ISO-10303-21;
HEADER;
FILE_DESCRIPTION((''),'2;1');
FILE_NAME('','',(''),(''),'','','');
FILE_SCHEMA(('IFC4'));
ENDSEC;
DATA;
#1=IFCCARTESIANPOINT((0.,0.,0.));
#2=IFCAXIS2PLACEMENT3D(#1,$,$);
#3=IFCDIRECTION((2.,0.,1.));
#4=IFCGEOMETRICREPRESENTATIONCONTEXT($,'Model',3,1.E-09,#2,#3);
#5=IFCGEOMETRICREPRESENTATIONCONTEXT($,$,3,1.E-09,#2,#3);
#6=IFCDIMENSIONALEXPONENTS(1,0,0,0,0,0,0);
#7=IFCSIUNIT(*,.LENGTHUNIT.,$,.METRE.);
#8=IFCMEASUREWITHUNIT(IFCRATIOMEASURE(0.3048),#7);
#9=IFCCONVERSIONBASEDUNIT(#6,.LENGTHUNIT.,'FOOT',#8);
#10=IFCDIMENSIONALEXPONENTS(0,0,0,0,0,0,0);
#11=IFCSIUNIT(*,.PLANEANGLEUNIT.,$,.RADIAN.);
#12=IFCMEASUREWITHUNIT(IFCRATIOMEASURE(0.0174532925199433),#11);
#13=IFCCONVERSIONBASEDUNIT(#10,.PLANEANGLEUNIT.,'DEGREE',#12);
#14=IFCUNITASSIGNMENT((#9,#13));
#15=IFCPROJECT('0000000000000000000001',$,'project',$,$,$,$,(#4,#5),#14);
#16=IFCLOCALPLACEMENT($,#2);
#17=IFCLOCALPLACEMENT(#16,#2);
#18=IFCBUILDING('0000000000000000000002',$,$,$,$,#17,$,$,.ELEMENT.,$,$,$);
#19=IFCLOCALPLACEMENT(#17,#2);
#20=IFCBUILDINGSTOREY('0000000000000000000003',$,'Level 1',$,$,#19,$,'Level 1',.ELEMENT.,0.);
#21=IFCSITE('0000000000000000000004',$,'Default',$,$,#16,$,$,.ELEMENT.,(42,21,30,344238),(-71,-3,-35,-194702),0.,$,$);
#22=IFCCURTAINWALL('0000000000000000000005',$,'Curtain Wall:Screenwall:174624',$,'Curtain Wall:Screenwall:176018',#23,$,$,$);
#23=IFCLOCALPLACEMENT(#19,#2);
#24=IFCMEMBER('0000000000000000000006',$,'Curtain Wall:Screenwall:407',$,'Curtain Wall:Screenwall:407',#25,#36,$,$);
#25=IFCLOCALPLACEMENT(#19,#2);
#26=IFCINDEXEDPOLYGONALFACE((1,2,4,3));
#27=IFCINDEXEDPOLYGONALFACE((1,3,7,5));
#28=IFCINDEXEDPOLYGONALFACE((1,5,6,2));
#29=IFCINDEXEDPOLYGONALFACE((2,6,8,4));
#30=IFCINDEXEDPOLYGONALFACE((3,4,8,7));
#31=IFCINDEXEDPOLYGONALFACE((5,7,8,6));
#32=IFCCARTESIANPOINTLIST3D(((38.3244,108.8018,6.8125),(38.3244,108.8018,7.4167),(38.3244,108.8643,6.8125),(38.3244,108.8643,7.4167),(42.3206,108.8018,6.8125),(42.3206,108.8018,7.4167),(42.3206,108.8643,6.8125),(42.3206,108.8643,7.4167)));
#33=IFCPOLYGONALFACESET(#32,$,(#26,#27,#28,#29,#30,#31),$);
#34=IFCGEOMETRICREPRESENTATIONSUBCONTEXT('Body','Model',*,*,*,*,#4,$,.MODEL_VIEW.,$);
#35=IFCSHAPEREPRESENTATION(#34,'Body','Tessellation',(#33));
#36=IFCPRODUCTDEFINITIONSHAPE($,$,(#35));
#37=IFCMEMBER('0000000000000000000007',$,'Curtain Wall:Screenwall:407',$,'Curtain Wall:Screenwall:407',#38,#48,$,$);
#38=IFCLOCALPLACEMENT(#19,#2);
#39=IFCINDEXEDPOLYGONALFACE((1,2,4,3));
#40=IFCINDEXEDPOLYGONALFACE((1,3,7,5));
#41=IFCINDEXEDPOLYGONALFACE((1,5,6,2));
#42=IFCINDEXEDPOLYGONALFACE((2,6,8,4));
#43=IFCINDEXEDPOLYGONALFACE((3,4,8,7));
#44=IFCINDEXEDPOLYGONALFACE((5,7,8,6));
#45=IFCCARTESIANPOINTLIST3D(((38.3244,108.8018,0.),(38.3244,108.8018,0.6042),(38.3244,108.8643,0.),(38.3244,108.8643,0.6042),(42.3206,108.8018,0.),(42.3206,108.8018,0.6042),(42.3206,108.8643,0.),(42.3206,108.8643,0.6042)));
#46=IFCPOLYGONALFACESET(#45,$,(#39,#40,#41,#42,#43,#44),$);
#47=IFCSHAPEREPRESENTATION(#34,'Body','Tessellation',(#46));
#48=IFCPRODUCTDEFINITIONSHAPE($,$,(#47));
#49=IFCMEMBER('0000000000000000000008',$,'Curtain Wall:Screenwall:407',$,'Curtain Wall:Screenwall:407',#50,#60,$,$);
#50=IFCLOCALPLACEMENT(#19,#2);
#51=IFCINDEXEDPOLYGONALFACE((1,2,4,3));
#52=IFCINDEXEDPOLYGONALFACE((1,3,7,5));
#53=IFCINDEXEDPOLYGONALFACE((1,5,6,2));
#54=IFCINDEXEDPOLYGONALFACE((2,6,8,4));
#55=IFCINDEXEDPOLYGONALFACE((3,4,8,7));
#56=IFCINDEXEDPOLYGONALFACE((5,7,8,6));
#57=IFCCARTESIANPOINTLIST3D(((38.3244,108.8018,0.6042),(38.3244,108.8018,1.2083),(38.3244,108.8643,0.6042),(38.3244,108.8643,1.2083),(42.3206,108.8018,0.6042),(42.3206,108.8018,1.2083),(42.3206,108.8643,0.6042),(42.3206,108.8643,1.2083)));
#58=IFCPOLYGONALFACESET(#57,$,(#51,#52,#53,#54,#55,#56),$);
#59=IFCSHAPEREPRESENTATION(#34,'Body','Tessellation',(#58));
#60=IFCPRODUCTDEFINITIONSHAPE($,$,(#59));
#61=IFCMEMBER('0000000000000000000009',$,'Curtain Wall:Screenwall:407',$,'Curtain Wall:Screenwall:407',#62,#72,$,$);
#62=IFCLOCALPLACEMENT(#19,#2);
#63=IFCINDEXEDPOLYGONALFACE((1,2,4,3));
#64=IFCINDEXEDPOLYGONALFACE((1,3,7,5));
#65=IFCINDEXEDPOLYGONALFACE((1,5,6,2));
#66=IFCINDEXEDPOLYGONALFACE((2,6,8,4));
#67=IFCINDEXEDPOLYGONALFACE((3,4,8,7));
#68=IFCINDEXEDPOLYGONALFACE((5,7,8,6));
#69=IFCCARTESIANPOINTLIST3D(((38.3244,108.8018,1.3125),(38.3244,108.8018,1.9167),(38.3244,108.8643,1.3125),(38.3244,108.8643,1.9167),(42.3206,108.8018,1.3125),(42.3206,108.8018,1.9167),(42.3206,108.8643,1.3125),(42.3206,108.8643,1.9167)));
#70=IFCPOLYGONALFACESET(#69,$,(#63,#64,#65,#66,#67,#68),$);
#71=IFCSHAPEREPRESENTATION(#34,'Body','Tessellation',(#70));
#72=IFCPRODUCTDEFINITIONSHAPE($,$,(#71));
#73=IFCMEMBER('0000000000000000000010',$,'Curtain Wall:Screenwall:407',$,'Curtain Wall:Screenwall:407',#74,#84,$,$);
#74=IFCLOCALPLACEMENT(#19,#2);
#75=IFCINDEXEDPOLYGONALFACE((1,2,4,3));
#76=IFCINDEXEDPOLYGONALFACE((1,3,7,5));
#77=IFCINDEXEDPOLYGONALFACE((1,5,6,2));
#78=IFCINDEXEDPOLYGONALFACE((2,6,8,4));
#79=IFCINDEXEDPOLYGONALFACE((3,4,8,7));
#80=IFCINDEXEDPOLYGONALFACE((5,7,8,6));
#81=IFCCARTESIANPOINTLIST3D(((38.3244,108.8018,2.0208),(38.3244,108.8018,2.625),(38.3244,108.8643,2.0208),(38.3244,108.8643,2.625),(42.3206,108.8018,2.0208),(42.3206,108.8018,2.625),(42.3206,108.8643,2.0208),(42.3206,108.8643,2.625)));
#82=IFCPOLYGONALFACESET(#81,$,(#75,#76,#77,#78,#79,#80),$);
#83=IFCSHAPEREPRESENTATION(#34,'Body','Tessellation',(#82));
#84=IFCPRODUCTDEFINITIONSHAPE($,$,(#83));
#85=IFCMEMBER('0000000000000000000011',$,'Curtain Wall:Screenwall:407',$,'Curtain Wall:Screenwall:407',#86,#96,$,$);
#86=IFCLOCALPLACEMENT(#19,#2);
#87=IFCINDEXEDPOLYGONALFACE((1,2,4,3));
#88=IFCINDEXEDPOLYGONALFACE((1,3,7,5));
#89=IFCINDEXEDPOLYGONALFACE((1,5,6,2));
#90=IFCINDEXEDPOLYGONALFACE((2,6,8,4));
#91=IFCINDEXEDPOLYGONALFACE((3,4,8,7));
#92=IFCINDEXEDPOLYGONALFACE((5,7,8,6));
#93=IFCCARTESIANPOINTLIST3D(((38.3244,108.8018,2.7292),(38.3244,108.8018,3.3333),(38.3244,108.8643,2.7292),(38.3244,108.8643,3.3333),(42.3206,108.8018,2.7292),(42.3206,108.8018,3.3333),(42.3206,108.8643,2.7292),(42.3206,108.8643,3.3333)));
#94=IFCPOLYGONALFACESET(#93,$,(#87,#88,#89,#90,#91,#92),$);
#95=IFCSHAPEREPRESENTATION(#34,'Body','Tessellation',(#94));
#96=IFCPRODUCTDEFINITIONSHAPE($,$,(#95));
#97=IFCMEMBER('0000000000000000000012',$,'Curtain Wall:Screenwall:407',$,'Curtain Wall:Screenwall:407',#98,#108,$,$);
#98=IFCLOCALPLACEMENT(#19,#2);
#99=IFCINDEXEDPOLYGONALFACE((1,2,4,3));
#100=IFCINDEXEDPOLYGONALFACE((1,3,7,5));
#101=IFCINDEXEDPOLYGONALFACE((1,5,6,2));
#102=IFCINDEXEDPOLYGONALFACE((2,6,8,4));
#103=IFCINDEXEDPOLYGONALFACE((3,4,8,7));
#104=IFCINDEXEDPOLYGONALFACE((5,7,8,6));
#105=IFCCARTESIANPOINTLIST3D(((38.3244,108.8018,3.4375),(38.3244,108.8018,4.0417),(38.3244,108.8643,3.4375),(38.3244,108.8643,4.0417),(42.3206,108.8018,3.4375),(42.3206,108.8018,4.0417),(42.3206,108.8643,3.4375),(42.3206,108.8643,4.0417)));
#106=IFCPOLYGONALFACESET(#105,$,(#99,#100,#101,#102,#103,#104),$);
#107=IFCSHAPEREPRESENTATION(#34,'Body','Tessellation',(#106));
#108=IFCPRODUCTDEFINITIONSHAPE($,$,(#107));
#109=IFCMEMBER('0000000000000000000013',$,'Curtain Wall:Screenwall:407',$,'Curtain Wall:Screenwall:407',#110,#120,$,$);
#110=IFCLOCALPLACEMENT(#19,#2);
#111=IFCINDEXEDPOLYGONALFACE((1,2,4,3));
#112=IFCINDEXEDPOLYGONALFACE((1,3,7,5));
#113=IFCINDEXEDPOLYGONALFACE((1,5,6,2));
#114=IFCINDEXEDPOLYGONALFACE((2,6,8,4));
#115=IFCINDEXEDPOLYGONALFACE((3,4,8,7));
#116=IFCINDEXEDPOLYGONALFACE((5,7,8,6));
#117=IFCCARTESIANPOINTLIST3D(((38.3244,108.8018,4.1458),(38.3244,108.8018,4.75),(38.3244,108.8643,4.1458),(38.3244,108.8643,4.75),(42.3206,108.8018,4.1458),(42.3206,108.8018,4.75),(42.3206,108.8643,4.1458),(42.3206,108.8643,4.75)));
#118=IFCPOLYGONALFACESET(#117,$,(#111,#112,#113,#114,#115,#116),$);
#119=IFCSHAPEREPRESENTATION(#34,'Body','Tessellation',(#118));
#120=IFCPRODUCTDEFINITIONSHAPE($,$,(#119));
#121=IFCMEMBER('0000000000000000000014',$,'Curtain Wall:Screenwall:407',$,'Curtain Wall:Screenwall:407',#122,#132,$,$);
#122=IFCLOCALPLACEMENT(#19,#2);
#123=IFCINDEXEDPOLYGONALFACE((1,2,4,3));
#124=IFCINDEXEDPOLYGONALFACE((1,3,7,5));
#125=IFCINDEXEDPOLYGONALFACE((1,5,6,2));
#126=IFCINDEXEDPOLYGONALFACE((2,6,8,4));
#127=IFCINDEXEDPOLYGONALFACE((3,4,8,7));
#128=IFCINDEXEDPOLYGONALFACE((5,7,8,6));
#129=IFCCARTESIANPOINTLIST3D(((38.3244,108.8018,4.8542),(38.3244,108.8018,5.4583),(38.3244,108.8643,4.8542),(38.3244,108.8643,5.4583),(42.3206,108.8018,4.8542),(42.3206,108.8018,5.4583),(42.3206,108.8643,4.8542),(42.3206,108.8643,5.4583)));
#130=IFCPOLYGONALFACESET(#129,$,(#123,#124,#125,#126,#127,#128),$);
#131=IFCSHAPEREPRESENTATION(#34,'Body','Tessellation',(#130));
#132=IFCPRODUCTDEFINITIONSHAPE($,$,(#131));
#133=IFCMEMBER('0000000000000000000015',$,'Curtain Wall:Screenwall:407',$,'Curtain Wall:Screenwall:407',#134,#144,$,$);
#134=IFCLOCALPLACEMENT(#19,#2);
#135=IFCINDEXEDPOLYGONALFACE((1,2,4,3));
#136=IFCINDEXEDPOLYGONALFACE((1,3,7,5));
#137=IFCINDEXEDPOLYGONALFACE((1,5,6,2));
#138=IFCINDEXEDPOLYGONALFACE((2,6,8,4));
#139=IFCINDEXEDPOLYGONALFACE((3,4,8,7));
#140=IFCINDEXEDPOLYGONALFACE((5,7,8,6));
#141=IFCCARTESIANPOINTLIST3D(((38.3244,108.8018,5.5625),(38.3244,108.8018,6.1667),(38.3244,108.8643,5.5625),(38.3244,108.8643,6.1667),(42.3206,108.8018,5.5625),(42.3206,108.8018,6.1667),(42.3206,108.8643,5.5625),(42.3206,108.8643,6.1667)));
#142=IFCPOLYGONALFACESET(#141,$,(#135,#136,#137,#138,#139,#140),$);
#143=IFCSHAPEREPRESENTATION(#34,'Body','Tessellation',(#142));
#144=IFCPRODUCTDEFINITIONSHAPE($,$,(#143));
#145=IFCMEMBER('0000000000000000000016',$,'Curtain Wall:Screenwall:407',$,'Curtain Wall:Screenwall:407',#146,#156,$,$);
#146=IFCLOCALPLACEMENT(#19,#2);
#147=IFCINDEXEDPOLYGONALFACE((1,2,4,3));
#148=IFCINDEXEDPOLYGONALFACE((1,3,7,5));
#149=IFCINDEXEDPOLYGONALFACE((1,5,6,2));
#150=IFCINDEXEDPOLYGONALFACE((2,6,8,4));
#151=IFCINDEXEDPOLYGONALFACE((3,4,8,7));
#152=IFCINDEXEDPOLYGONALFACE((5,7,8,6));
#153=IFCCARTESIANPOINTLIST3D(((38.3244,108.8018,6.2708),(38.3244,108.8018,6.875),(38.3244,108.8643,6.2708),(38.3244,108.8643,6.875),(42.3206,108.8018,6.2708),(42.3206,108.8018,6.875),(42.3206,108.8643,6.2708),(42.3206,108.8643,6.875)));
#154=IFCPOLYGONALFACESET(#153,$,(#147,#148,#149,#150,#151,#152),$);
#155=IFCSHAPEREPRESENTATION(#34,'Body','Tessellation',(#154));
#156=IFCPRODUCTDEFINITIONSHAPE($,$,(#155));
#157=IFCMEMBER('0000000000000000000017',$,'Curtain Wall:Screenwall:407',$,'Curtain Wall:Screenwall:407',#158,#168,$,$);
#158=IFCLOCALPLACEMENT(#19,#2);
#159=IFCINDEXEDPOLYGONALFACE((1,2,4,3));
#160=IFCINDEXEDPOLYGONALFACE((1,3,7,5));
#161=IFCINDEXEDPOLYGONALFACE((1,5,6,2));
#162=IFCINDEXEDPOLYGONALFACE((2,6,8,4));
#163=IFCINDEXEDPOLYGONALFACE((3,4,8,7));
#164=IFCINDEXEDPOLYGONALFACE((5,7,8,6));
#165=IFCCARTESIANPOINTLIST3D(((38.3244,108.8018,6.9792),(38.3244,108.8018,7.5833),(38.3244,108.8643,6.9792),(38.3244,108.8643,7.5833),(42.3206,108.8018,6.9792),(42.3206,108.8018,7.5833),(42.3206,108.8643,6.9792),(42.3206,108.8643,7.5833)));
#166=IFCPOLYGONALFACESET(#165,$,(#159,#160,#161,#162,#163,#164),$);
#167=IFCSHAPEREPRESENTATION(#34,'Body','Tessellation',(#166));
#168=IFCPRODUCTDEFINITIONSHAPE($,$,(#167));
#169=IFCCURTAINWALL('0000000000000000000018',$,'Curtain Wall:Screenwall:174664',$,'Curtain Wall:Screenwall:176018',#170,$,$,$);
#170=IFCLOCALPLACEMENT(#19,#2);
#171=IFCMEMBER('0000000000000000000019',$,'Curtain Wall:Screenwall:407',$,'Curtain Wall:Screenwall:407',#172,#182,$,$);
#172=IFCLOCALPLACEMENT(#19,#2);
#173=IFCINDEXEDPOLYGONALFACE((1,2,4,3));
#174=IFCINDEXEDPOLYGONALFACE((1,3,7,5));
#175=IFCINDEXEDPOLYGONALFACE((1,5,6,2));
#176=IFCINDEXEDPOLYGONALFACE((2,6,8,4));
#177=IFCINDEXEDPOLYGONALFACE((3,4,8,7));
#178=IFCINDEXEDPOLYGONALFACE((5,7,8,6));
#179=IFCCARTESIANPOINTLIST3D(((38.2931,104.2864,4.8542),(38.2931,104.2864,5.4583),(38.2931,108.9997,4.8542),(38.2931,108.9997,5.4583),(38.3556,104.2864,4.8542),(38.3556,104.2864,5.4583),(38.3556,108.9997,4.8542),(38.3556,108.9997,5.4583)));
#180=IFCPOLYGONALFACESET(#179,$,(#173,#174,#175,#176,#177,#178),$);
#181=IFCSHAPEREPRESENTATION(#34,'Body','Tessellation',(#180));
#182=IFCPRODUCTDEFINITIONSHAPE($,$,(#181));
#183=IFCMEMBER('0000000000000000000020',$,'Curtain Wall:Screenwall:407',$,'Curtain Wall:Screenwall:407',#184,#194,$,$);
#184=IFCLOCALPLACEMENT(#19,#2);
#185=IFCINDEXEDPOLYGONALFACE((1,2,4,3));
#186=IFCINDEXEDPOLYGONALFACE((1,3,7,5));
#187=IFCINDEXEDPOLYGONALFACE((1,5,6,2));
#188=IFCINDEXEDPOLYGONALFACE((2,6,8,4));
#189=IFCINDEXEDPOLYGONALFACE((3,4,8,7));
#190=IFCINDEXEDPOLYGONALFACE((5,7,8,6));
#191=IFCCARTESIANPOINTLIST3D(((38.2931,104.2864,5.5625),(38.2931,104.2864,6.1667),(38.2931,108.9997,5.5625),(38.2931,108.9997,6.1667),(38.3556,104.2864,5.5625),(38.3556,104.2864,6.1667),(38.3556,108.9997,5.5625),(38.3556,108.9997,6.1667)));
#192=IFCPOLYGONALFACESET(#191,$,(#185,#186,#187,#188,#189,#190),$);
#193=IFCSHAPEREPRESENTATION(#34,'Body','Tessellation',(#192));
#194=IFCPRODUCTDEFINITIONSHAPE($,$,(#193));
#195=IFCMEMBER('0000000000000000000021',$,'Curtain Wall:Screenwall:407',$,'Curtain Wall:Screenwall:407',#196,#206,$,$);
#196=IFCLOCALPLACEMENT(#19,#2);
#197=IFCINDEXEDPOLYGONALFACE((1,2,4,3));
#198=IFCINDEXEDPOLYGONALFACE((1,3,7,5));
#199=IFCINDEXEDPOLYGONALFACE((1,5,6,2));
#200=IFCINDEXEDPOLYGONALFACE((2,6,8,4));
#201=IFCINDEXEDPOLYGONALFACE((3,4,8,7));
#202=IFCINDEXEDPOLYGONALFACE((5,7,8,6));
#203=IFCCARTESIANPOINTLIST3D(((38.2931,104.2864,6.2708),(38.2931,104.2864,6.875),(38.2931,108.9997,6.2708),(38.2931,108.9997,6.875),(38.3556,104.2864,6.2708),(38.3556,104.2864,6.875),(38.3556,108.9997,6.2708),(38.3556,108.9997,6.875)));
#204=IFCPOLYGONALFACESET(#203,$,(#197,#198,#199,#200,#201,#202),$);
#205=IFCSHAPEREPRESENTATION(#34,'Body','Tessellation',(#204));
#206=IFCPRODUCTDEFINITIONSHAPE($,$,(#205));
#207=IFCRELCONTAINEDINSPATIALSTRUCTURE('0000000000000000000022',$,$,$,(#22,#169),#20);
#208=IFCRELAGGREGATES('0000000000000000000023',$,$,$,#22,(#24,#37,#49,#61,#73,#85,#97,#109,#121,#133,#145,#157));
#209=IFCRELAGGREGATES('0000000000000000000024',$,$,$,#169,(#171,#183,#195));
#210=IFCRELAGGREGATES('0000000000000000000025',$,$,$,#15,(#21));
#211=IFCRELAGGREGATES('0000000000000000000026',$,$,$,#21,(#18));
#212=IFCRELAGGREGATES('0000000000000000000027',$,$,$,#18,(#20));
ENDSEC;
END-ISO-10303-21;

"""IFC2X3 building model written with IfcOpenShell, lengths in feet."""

from ifc_helpers import new_model, entity, si_unit, converted_unit, direction, frame, frame_2d, origin, origin_2d_with_axis, place, context, subcontext, project, spatial, rectangle, extrude, element, aggregate, save


model = new_model("IFC2X3")

# Units and contexts
model_context = context("Model", 3, precision=1e-09, world=origin(), true_north=direction((2.0, 0.0, 1.0)))
context_of_model = context(None, 3, precision=1e-09, world=origin(), true_north=direction((2.0, 0.0, 1.0)))
body_context = subcontext(model_context, "Body", "Model", "MODEL_VIEW")
ifc_project = project(units=[converted_unit("LENGTHUNIT", "FOOT", entity("IfcRatioMeasure", 0.3048), si_unit("LENGTHUNIT", "METRE"), dimensions=[1, 0, 0, 0, 0, 0, 0]), converted_unit("PLANEANGLEUNIT", "DEGREE", entity("IfcRatioMeasure", 0.0174532925199433), si_unit("PLANEANGLEUNIT", "RADIAN"), dimensions=[0, 0, 0, 0, 0, 0, 0])], contexts=[model_context, context_of_model])

# Site, building, storey
site_placement = place(None, origin())
site = spatial("IfcSite", under=ifc_project, at=site_placement, Name="Default", CompositionType="ELEMENT", RefLatitude=(42, 21, 30, 344238), RefLongitude=(-71, -3, -35, -194702), RefElevation=0.0)
building_placement = place(site_placement, origin())
building = spatial("IfcBuilding", under=site, at=building_placement, CompositionType="ELEMENT")
storey_placement = place(building_placement, origin())
storey = spatial("IfcBuildingStorey", under=building, at=storey_placement, Name="Level 1", LongName="Level 1", CompositionType="ELEMENT", Elevation=0.0)

# Curtain walls, members
curtain_wall_1_placement = place(storey_placement, origin())
curtain_wall_1 = element("IfcCurtainWall", 1, at=curtain_wall_1_placement, inside=storey, Name="Curtain Wall:Screenwall:174624", ObjectType="Curtain Wall:Screenwall:176018")
member_1_placement = place(curtain_wall_1_placement, frame((38.3244, 108.8018, 6.8125)))
member_1 = element("IfcMember", 2, at=member_1_placement, Name="Curtain Wall:Screenwall:407", ObjectType="Curtain Wall:Screenwall:407", context=body_context, shape_type="SweptSolid", body=[
    extrude(rectangle(XDim=3.9962, YDim=0.0625, at=frame_2d((0.0, 0.0), x_axis=(1.0, 0.0))), frame((1.9981, 0.0312, 0.0)), (0.0, 0.0, 1.0), 0.6042),
])
member_2_placement = place(curtain_wall_1_placement, frame((38.3244, 108.8018, 0.0)))
member_2 = element("IfcMember", 3, at=member_2_placement, Name="Curtain Wall:Screenwall:407", ObjectType="Curtain Wall:Screenwall:407", context=body_context, shape_type="SweptSolid", body=[
    extrude(rectangle(XDim=3.9962, YDim=0.0625, at=frame_2d((0.0, 0.0), x_axis=(1.0, 0.0))), frame((1.9981, 0.0312, 0.0), z_axis=(0.0, 0.0, 1.0), x_axis=(-1.0, 0.0, 0.0)), (0.0, 0.0, 1.0), 0.6042),
])
member_3_placement = place(curtain_wall_1_placement, frame((38.3244, 108.8018, 0.6042)))
member_3 = element("IfcMember", 4, at=member_3_placement, Name="Curtain Wall:Screenwall:407", ObjectType="Curtain Wall:Screenwall:407", context=body_context, shape_type="SweptSolid", body=[
    extrude(rectangle(XDim=3.9962, YDim=0.0625, at=frame_2d((0.0, 0.0), x_axis=(1.0, 0.0))), frame((1.9981, 0.0312, 0.0)), (0.0, 0.0, 1.0), 0.6042),
])
member_4_placement = place(curtain_wall_1_placement, frame((38.3244, 108.8018, 1.3125)))
member_4 = element("IfcMember", 5, at=member_4_placement, Name="Curtain Wall:Screenwall:407", ObjectType="Curtain Wall:Screenwall:407", context=body_context, shape_type="SweptSolid", body=[
    extrude(rectangle(XDim=3.9962, YDim=0.0625, at=frame_2d((0.0, 0.0), x_axis=(1.0, 0.0))), frame((1.9981, 0.0312, 0.0)), (0.0, 0.0, 1.0), 0.6042),
])
member_5_placement = place(curtain_wall_1_placement, frame((38.3244, 108.8018, 2.0208)))
member_5 = element("IfcMember", 6, at=member_5_placement, Name="Curtain Wall:Screenwall:407", ObjectType="Curtain Wall:Screenwall:407", context=body_context, shape_type="SweptSolid", body=[
    extrude(rectangle(XDim=3.9962, YDim=0.0625, at=frame_2d((0.0, 0.0), x_axis=(1.0, 0.0))), frame((1.9981, 0.0312, 0.0)), (0.0, 0.0, 1.0), 0.6042),
])
member_6_placement = place(curtain_wall_1_placement, frame((38.3244, 108.8018, 2.7292)))
member_6 = element("IfcMember", 7, at=member_6_placement, Name="Curtain Wall:Screenwall:407", ObjectType="Curtain Wall:Screenwall:407", context=body_context, shape_type="SweptSolid", body=[
    extrude(rectangle(XDim=3.9962, YDim=0.0625, at=frame_2d((0.0, 0.0), x_axis=(1.0, 0.0))), frame((1.9981, 0.0312, 0.0)), (0.0, 0.0, 1.0), 0.6042),
])
member_7_placement = place(curtain_wall_1_placement, frame((38.3244, 108.8018, 3.4375)))
member_7 = element("IfcMember", 8, at=member_7_placement, Name="Curtain Wall:Screenwall:407", ObjectType="Curtain Wall:Screenwall:407", context=body_context, shape_type="SweptSolid", body=[
    extrude(rectangle(XDim=3.9962, YDim=0.0625, at=frame_2d((0.0, 0.0), x_axis=(1.0, 0.0))), frame((1.9981, 0.0312, 0.0)), (0.0, 0.0, 1.0), 0.6042),
])
member_8_placement = place(curtain_wall_1_placement, frame((38.3244, 108.8018, 4.1458)))
member_8 = element("IfcMember", 9, at=member_8_placement, Name="Curtain Wall:Screenwall:407", ObjectType="Curtain Wall:Screenwall:407", context=body_context, shape_type="SweptSolid", body=[
    extrude(rectangle(XDim=3.9962, YDim=0.0625, at=frame_2d((0.0, 0.0), x_axis=(1.0, 0.0))), frame((1.9981, 0.0312, 0.0)), (0.0, 0.0, 1.0), 0.6042),
])
member_9_placement = place(curtain_wall_1_placement, frame((38.3244, 108.8018, 4.8542)))
member_9 = element("IfcMember", 10, at=member_9_placement, Name="Curtain Wall:Screenwall:407", ObjectType="Curtain Wall:Screenwall:407", context=body_context, shape_type="SweptSolid", body=[
    extrude(rectangle(XDim=3.9962, YDim=0.0625, at=frame_2d((0.0, 0.0), x_axis=(1.0, 0.0))), frame((1.9981, 0.0312, 0.0)), (0.0, 0.0, 1.0), 0.6042),
])
member_10_placement = place(curtain_wall_1_placement, frame((38.3244, 108.8018, 5.5625)))
member_10 = element("IfcMember", 11, at=member_10_placement, Name="Curtain Wall:Screenwall:407", ObjectType="Curtain Wall:Screenwall:407", context=body_context, shape_type="SweptSolid", body=[
    extrude(rectangle(XDim=3.9962, YDim=0.0625, at=frame_2d((0.0, 0.0), x_axis=(1.0, 0.0))), frame((1.9981, 0.0312, 0.0)), (0.0, 0.0, 1.0), 0.6042),
])
member_11_placement = place(curtain_wall_1_placement, frame((38.3244, 108.8018, 6.2708)))
member_11 = element("IfcMember", 12, at=member_11_placement, Name="Curtain Wall:Screenwall:407", ObjectType="Curtain Wall:Screenwall:407", context=body_context, shape_type="SweptSolid", body=[
    extrude(rectangle(XDim=3.9962, YDim=0.0625, at=frame_2d((0.0, 0.0), x_axis=(1.0, 0.0))), frame((1.9981, 0.0312, 0.0)), (0.0, 0.0, 1.0), 0.6042),
])
member_12_placement = place(curtain_wall_1_placement, frame((38.3244, 108.8018, 6.9792)))
member_12 = element("IfcMember", 13, at=member_12_placement, Name="Curtain Wall:Screenwall:407", ObjectType="Curtain Wall:Screenwall:407", context=body_context, shape_type="SweptSolid", body=[
    extrude(rectangle(XDim=3.9962, YDim=0.0625, at=frame_2d((0.0, 0.0), x_axis=(1.0, 0.0))), frame((1.9981, 0.0312, 0.0)), (0.0, 0.0, 1.0), 0.6042),
])
aggregate(curtain_wall_1, [member_1, member_2, member_3, member_4, member_5, member_6, member_7, member_8, member_9, member_10, member_11, member_12])
curtain_wall_2_placement = place(storey_placement, origin())
curtain_wall_2 = element("IfcCurtainWall", 14, at=curtain_wall_2_placement, inside=storey, Name="Curtain Wall:Screenwall:174664", ObjectType="Curtain Wall:Screenwall:176018")
member_13_placement = place(curtain_wall_2_placement, frame((38.2931, 104.2864, 4.8542)))
member_13 = element("IfcMember", 15, at=member_13_placement, Name="Curtain Wall:Screenwall:407", ObjectType="Curtain Wall:Screenwall:407", context=body_context, shape_type="SweptSolid", body=[
    extrude(rectangle(XDim=4.7134, YDim=0.0625, at=origin_2d_with_axis()), frame((0.0312, 2.3567, 0.0), z_axis=(0.0, 0.0, 1.0), x_axis=(0.0, 1.0, 0.0)), (0.0, 0.0, 1.0), 0.6042),
])
member_14_placement = place(curtain_wall_2_placement, frame((38.2931, 104.2864, 5.5625)))
member_14 = element("IfcMember", 16, at=member_14_placement, Name="Curtain Wall:Screenwall:407", ObjectType="Curtain Wall:Screenwall:407", context=body_context, shape_type="SweptSolid", body=[
    extrude(rectangle(XDim=4.7134, YDim=0.0625, at=origin_2d_with_axis()), frame((0.0312, 2.3567, 0.0), z_axis=(0.0, 0.0, 1.0), x_axis=(0.0, 1.0, 0.0)), (0.0, 0.0, 1.0), 0.6042),
])
member_15_placement = place(curtain_wall_2_placement, frame((38.2931, 104.2864, 6.2708)))
member_15 = element("IfcMember", 17, at=member_15_placement, Name="Curtain Wall:Screenwall:407", ObjectType="Curtain Wall:Screenwall:407", context=body_context, shape_type="SweptSolid", body=[
    extrude(rectangle(XDim=4.7134, YDim=0.0625, at=origin_2d_with_axis()), frame((0.0312, 2.3567, 0.0), z_axis=(0.0, 0.0, 1.0), x_axis=(0.0, 1.0, 0.0)), (0.0, 0.0, 1.0), 0.6042),
])
aggregate(curtain_wall_2, [member_13, member_14, member_15])

save(model, "model.ifc")
